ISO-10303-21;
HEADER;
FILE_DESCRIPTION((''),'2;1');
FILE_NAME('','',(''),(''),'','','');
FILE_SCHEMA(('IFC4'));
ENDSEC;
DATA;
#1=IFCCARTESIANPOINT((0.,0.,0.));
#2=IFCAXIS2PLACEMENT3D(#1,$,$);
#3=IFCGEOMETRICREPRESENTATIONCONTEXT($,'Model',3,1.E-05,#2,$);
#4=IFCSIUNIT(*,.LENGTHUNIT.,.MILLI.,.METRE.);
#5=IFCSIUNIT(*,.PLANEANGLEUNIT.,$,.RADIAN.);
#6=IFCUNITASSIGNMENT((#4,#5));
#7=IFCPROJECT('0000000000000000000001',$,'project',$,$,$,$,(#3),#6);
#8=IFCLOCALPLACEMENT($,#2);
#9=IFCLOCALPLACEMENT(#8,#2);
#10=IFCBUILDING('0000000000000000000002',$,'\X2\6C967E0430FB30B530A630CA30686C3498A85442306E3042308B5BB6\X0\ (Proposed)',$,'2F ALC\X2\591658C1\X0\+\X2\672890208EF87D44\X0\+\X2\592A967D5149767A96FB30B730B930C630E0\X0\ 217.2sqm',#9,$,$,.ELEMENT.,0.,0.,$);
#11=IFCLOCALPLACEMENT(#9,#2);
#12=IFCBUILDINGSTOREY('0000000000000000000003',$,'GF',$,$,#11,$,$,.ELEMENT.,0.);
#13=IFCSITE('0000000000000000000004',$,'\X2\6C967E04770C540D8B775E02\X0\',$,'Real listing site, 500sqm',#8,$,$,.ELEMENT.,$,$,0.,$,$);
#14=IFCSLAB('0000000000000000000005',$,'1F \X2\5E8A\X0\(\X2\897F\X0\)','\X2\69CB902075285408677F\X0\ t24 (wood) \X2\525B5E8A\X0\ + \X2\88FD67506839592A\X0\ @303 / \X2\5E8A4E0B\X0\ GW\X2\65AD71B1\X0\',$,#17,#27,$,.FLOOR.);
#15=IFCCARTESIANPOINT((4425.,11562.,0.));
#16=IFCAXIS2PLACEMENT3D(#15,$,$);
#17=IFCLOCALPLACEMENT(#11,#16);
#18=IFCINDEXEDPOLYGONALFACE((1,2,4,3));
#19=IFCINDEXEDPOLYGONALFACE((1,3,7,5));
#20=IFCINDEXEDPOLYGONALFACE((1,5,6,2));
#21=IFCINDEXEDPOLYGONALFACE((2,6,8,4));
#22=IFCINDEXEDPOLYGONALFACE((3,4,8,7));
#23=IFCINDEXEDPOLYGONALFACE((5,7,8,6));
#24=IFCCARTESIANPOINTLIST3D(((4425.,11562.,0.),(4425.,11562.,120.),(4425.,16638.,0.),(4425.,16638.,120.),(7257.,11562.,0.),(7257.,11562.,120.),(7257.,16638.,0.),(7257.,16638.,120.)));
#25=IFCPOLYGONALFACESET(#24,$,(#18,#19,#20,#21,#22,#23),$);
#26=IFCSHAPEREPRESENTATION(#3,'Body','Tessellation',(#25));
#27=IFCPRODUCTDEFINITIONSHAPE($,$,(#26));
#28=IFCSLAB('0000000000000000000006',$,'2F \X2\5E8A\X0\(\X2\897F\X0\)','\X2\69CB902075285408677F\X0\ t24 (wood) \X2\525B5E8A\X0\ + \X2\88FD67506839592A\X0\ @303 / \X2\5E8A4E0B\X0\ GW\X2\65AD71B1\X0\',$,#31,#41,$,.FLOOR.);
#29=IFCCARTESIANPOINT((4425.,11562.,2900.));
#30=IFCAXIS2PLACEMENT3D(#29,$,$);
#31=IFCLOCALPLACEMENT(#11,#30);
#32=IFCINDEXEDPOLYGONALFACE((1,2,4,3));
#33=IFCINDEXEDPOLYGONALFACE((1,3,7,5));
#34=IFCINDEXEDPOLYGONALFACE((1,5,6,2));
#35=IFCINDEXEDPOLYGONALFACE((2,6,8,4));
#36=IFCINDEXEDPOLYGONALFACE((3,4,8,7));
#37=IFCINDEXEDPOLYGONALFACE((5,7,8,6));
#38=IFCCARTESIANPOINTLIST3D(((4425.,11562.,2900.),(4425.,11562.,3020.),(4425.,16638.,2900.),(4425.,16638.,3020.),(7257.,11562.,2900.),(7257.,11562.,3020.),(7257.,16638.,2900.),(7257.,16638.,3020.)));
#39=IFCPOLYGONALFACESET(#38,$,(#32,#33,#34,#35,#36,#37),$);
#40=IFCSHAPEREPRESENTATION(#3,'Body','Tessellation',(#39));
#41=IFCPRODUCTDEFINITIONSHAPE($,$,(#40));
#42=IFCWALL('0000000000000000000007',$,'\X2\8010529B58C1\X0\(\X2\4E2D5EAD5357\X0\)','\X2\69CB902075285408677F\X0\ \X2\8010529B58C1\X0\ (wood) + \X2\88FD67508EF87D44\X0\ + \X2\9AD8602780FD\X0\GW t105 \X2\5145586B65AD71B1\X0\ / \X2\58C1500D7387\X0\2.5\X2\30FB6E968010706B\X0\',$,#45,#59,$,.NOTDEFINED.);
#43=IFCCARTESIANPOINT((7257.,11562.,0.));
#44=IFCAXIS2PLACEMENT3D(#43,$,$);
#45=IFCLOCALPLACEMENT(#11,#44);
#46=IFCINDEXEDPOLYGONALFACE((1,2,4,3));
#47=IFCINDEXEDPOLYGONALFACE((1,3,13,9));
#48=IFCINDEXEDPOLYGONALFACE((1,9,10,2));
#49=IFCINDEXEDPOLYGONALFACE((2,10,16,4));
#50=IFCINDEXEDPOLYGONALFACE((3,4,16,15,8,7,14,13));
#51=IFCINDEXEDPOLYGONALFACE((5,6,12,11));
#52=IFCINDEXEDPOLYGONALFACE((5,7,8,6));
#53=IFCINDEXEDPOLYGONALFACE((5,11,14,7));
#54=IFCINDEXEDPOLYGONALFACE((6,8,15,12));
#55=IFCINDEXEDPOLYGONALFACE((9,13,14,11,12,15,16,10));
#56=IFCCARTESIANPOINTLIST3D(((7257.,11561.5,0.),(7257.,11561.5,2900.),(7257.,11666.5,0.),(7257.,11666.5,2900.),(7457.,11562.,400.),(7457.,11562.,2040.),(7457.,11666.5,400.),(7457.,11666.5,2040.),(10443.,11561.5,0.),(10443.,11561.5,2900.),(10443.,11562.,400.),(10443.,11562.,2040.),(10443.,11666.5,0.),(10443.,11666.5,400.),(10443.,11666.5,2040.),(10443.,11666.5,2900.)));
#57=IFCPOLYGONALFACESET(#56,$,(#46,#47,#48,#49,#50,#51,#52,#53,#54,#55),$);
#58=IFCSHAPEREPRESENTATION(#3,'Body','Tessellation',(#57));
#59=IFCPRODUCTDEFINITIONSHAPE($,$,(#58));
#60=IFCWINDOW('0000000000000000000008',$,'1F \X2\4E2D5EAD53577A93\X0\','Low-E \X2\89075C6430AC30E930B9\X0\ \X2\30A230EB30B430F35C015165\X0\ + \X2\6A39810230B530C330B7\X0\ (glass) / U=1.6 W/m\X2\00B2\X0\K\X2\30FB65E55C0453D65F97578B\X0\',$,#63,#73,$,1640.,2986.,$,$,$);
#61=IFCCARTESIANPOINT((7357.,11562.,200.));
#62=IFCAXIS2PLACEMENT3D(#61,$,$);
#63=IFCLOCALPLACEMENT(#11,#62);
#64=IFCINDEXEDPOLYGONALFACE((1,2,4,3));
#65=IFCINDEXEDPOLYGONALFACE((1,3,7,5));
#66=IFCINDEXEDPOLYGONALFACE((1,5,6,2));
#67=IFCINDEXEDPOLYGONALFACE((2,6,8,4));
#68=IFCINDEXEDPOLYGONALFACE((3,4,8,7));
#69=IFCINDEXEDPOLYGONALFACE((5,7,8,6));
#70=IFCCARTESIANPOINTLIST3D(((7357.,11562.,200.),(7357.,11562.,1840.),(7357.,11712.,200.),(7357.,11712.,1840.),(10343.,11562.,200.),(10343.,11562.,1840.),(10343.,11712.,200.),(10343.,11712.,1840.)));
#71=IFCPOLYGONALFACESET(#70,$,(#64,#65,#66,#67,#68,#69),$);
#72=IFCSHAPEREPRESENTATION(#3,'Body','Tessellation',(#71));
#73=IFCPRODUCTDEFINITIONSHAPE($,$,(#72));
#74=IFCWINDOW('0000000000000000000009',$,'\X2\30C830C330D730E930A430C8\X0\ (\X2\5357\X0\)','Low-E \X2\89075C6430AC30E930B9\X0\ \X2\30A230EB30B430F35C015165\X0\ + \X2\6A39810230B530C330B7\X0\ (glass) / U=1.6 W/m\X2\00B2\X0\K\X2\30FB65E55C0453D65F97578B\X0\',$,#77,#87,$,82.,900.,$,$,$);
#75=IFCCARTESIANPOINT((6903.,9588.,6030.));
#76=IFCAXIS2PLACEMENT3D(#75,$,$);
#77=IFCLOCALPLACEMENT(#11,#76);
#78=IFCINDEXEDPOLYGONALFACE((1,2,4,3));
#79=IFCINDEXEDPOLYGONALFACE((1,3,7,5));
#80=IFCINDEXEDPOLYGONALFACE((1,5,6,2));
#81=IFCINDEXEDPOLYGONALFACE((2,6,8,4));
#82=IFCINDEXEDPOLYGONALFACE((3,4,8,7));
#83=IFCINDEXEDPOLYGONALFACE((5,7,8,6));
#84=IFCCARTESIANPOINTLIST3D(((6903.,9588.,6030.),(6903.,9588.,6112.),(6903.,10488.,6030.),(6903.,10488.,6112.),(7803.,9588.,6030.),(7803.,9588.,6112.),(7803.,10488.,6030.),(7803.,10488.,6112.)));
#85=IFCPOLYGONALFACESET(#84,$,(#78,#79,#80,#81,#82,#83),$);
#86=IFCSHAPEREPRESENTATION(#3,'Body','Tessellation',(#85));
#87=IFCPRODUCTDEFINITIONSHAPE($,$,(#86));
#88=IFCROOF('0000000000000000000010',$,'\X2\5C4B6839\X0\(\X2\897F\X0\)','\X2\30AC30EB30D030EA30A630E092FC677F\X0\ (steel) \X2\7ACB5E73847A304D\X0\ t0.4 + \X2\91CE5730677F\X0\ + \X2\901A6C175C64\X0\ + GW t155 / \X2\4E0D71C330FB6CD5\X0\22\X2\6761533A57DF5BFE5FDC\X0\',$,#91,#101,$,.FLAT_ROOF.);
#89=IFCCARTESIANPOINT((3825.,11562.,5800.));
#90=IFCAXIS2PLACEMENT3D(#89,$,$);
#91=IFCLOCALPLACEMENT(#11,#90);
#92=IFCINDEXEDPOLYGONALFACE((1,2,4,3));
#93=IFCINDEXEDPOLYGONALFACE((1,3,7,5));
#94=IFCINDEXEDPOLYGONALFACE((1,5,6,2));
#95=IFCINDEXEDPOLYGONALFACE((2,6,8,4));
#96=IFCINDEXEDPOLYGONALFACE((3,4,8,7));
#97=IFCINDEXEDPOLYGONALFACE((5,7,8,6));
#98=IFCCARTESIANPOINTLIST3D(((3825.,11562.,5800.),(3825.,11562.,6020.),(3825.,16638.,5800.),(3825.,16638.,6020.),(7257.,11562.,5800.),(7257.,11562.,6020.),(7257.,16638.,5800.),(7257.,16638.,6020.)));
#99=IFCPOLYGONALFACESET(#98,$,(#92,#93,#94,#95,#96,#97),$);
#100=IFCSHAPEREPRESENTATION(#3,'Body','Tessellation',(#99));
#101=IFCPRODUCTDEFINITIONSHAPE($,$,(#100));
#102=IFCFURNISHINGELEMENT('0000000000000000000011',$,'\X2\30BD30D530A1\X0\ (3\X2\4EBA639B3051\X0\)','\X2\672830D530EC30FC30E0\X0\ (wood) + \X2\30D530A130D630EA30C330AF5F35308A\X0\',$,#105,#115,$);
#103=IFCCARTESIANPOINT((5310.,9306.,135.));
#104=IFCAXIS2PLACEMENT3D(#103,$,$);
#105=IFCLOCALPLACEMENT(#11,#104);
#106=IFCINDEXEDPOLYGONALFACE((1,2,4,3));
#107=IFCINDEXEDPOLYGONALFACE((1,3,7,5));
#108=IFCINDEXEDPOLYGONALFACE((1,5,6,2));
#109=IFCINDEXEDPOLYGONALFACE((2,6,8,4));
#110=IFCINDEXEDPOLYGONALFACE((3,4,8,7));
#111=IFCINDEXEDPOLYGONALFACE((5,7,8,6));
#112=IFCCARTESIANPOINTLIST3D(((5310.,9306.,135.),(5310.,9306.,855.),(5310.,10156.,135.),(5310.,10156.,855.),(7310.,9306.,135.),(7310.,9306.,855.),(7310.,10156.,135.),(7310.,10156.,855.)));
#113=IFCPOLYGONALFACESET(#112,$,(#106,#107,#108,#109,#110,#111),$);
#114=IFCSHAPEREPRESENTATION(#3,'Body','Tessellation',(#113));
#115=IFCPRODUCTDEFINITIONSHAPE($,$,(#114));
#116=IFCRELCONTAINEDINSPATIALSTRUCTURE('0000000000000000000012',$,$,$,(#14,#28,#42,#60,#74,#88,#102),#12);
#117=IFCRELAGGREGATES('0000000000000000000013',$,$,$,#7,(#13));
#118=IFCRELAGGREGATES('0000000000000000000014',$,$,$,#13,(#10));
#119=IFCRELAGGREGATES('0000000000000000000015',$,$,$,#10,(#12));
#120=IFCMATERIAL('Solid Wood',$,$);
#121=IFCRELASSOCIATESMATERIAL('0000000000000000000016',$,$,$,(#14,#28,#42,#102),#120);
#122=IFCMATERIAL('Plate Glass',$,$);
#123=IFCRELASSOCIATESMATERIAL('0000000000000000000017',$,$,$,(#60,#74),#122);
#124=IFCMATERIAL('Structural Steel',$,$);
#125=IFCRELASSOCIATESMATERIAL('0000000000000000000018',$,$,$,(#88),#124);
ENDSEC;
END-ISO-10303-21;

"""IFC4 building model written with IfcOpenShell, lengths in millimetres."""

from ifc_helpers import new_model, si_unit, frame, frame_2d, origin, place, context, project, spatial, rectangle, extrude, material, element, fill, save


model = new_model("IFC4")

# Units and contexts
model_context = context("Model", 3, precision=1e-05, world=origin())
ifc_project = project(units=[si_unit("LENGTHUNIT", "METRE", prefix="MILLI"), si_unit("PLANEANGLEUNIT", "RADIAN")], contexts=[model_context])

# Site, building, storey
site_placement = place(None, origin())
site = spatial("IfcSite", under=ifc_project, at=site_placement, Name="沖縄県名護市", ObjectType="Real listing site, 500sqm", CompositionType="ELEMENT", RefElevation=0.0)
building_placement = place(site_placement, origin())
building = spatial("IfcBuilding", under=site, at=building_placement, Name="沖縄・サウナと水風呂のある家 (Proposed)", ObjectType="2F ALC外壁+木造軸組+太陽光発電システム 217.2sqm", CompositionType="ELEMENT", ElevationOfRefHeight=0.0, ElevationOfTerrain=0.0)
storey_placement = place(building_placement, origin())
storey = spatial("IfcBuildingStorey", under=building, at=storey_placement, Name="GF", CompositionType="ELEMENT", Elevation=0.0)

# Shared definitions
ifc_material_1 = material(Name="Solid Wood")

# Slabs
slab_1_placement = place(storey_placement, frame((4425.0, 11562.0, 0.0)))
element("IfcSlab", 1, at=slab_1_placement, inside=storey, material=ifc_material_1, Name="1F 床(西)", Description="構造用合板 t24 (wood) 剛床 + 製材根太 @303 / 床下 GW断熱", PredefinedType="FLOOR", context=model_context, shape_type="SweptSolid", body=[
    extrude(rectangle(XDim=2832.0, YDim=5076.0, at=frame_2d((1416.0, 2538.0))), frame((4425.0, 11562.0, 0.0)), (0.0, 0.0, 1.0), 120.0),
])
slab_2_placement = place(storey_placement, frame((4425.0, 11562.0, 2900.0)))
element("IfcSlab", 2, at=slab_2_placement, inside=storey, material=ifc_material_1, Name="2F 床(西)", Description="構造用合板 t24 (wood) 剛床 + 製材根太 @303 / 床下 GW断熱", PredefinedType="FLOOR", context=model_context, shape_type="SweptSolid", body=[
    extrude(rectangle(XDim=2832.0, YDim=5076.0, at=frame_2d((1416.0, 2538.0))), frame((4425.0, 11562.0, 2900.0)), (0.0, 0.0, 1.0), 120.0),
])

# Wall, opening, window
wall_placement = place(storey_placement, frame((7257.0, 11562.0, 0.0)))
wall = element("IfcWall", 3, at=wall_placement, inside=storey, material=ifc_material_1, Name="耐力壁(中庭南)", Description="構造用合板 耐力壁 (wood) + 製材軸組 + 高性能GW t105 充填断熱 / 壁倍率2.5・準耐火", PredefinedType="NOTDEFINED", context=model_context, shape_type="SweptSolid", body=[
    extrude(rectangle(XDim=3186.0, YDim=105.0, at=frame_2d((1593.0, 52.0))), frame((7257.0, 11562.0, 0.0)), (0.0, 0.0, 1.0), 2900.0),
])
opening_placement = place(storey_placement, frame((7357.0, 11562.0, 200.0)))
opening = element("IfcOpeningElement", 4, at=opening_placement, cuts=wall, PredefinedType="NOTDEFINED", context=model_context, shape_type="SweptSolid", body=[
    extrude(rectangle(XDim=2986.0, YDim=150.0, at=frame_2d((1493.0, 75.0))), frame((7357.0, 11562.0, 200.0)), (0.0, 0.0, 1.0), 1640.0),
])
ifc_material_2 = material(Name="Plate Glass")
window_1_placement = place(storey_placement, frame((7357.0, 11562.0, 200.0)))
window_1 = element("IfcWindow", 5, at=window_1_placement, inside=storey, material=ifc_material_2, Name="1F 中庭南窓", Description="Low-E 複層ガラス アルゴン封入 + 樹脂サッシ (glass) / U=1.6 W/m²K・日射取得型", OverallHeight=1640.0, OverallWidth=2986.0, context=model_context, shape_type="SweptSolid", body=[
    extrude(rectangle(XDim=2986.0, YDim=150.0, at=frame_2d((1493.0, 75.0))), frame((7357.0, 11562.0, 200.0)), (0.0, 0.0, 1.0), 1640.0),
])
fill(opening, window_1)

# Window
window_2_placement = place(storey_placement, frame((6903.0, 9588.0, 6030.0)))
element("IfcWindow", 6, at=window_2_placement, inside=storey, material=ifc_material_2, Name="トップライト (南)", Description="Low-E 複層ガラス アルゴン封入 + 樹脂サッシ (glass) / U=1.6 W/m²K・日射取得型", OverallHeight=82.0, OverallWidth=900.0, context=model_context, shape_type="SweptSolid", body=[
    extrude(rectangle(XDim=900.0, YDim=900.0, at=frame_2d((450.0, 450.0))), frame((6903.0, 9588.0, 6030.0)), (0.0, 0.0, 1.0), 82.0),
])

# Roof
ifc_material_3 = material(Name="Structural Steel")
for number, where, name in (
    (7, (3825.0, 11562.0, 5800.0), "屋根(西)"),
):
    element("IfcRoof", number, at=place(storey_placement, frame(where)), inside=storey, material=ifc_material_3, Name=name, Description="ガルバリウム鋼板 (steel) 立平葺き t0.4 + 野地板 + 通気層 + GW t155 / 不燃・法22条区域対応", PredefinedType="FLAT_ROOF", context=model_context, shape_type="SweptSolid", body=[
        extrude(rectangle(XDim=3432.0, YDim=5076.0, at=frame_2d((1716.0, 2538.0))), frame((3825.0, 11562.0, 5800.0)), (0.0, 0.0, 1.0), 220.0),
    ])

# Furnishing element
furnishing_placement = place(storey_placement, frame((5310.0, 9306.0, 135.0)))
element("IfcFurnishingElement", 8, at=furnishing_placement, inside=storey, material=ifc_material_1, Name="ソファ (3人掛け)", Description="木フレーム (wood) + ファブリック張り", context=model_context, shape_type="SweptSolid", body=[
    extrude(rectangle(XDim=2000.0, YDim=850.0, at=frame_2d((1000.0, 425.0))), frame((5310.0, 9306.0, 135.0)), (0.0, 0.0, 1.0), 720.0),
])

save(model, "model.ifc")
